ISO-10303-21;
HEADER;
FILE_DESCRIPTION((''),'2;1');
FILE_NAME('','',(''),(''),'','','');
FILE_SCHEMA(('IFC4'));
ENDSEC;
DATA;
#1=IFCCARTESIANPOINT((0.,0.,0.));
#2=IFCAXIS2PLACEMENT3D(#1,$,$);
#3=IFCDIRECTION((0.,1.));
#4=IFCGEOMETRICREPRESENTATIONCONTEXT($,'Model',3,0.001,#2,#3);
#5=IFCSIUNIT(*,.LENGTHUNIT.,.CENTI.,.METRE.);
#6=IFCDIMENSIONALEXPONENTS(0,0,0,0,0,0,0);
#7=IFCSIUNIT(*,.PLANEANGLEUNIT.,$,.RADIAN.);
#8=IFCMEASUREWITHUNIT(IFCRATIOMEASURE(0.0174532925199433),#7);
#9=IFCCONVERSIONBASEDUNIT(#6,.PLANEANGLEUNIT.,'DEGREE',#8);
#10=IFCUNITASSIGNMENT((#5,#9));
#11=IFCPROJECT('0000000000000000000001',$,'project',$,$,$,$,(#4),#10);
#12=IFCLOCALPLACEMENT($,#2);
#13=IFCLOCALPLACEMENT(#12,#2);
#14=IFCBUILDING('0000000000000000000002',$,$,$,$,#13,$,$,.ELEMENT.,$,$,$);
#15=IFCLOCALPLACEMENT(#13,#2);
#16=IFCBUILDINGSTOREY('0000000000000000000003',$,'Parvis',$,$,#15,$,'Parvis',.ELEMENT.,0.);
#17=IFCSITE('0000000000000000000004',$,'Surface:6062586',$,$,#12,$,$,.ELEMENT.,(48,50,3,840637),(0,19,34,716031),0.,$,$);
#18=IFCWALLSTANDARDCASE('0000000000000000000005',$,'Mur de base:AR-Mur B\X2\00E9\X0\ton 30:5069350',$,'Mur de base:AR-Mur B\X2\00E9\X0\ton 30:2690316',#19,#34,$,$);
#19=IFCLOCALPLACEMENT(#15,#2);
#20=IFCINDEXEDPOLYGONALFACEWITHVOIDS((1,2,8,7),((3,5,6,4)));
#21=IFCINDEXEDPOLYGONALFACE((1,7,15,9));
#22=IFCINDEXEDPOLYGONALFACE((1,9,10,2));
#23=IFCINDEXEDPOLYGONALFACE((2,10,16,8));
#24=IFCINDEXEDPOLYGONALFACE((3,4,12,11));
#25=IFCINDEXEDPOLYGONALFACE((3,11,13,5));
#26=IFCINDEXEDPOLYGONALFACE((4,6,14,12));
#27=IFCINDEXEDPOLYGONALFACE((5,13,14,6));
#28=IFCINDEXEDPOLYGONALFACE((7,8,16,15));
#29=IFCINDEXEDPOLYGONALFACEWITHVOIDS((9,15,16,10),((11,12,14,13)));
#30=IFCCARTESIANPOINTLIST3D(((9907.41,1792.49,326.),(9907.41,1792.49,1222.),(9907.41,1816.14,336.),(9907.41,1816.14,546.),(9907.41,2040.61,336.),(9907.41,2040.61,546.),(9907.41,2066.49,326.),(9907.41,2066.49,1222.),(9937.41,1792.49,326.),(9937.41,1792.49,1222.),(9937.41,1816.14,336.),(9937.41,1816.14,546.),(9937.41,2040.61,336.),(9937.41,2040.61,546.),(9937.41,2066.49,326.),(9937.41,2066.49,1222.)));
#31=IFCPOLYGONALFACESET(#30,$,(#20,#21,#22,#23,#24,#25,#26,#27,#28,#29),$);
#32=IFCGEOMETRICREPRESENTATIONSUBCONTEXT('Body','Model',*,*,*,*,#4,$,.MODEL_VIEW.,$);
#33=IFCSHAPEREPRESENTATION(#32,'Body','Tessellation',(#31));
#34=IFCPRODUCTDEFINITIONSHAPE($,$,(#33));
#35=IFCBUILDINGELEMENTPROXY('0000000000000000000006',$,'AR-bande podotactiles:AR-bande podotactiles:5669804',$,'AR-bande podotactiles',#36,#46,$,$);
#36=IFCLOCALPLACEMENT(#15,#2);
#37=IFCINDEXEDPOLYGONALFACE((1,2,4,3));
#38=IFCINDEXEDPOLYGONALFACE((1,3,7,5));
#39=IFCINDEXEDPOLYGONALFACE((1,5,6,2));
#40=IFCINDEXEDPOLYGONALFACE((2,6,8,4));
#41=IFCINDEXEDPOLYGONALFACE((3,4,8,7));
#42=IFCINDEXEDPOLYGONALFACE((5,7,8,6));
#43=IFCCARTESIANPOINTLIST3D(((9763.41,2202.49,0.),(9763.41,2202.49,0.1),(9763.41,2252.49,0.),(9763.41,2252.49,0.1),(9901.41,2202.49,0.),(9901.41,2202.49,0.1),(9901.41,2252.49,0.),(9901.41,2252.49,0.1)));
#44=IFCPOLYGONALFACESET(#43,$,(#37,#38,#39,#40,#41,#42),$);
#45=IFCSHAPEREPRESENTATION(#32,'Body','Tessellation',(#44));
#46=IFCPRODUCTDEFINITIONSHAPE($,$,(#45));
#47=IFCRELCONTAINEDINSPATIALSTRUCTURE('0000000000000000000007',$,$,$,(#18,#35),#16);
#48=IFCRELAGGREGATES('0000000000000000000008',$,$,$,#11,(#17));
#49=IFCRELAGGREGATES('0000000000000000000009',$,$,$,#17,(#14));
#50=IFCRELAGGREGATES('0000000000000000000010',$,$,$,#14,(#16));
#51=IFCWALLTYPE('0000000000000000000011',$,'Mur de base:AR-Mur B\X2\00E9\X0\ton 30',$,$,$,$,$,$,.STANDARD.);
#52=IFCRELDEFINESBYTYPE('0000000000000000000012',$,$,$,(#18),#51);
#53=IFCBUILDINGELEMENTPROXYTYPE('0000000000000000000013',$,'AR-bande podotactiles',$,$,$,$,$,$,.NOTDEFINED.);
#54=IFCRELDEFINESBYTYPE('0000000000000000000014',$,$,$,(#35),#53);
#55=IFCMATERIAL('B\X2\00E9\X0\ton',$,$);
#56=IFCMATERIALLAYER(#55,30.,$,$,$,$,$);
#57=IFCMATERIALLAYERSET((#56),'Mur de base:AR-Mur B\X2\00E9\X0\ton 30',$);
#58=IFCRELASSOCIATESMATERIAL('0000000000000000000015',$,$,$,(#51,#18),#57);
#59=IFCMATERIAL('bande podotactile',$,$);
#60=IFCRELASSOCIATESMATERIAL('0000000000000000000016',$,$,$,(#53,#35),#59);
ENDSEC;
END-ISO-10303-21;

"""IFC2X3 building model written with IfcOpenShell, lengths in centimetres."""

from ifc_helpers import new_model, entity, si_unit, converted_unit, direction, frame, frame_2d, origin, origin_2d_with_axis, place, context, subcontext, project, spatial, rectangle, extrude, source, transform, mapped, material, layer, layer_set, layer_usage, type_object, type_shapes, element, save


model = new_model("IFC2X3")

# Units and contexts
model_context = context("Model", 3, precision=0.001, world=origin(), true_north=direction((0.0, 1.0)))
body_context = subcontext(model_context, "Body", "Model", "MODEL_VIEW")
ifc_project = project(units=[si_unit("LENGTHUNIT", "METRE", prefix="CENTI"), converted_unit("PLANEANGLEUNIT", "DEGREE", entity("IfcRatioMeasure", 0.0174532925199433), si_unit("PLANEANGLEUNIT", "RADIAN"), dimensions=[0, 0, 0, 0, 0, 0, 0])], contexts=[model_context])

# Site, building, storey
site_placement = place(None, origin())
site = spatial("IfcSite", under=ifc_project, at=site_placement, Name="Surface:6062586", CompositionType="ELEMENT", RefLatitude=(48, 50, 3, 840637), RefLongitude=(0, 19, 34, 716031), RefElevation=0.0)
building_placement = place(site_placement, origin())
building = spatial("IfcBuilding", under=site, at=building_placement, CompositionType="ELEMENT")
storey_placement = place(building_placement, frame((0.0, 0.0, 0.0)))
storey = spatial("IfcBuildingStorey", under=building, at=storey_placement, Name="Parvis", LongName="Parvis", CompositionType="ELEMENT", Elevation=0.0)

# Wall, opening
ifc_material_1 = material(Name="Béton")
ifc_layer_1 = layer(ifc_material_1, 30.0)
ifc_layer_set_1 = layer_set([ifc_layer_1], Name="Mur de base:AR-Mur Béton 30")
ifc_layer_usage_1 = layer_usage(ifc_layer_set_1, "AXIS2", "NEGATIVE", 15.0)
wall_type = type_object("IfcWallType", Name="Mur de base:AR-Mur Béton 30", PredefinedType="STANDARD", material=ifc_layer_set_1)
wall_placement = place(storey_placement, frame((9922.41, 2066.49, 326.0), z_axis=(0.0, 0.0, 1.0), x_axis=(0.0, -1.0, 0.0)))
wall = element("IfcWallStandardCase", 1, at=wall_placement, inside=storey, type_object=wall_type, material=ifc_layer_usage_1, Name="Mur de base:AR-Mur Béton 30:5069350", ObjectType="Mur de base:AR-Mur Béton 30:2690316", context=body_context, shape_type="SweptSolid", body=[
    extrude(rectangle(XDim=274.0, YDim=30.0, at=frame_2d((137.0, 0.0), x_axis=(-1.0, 0.0))), origin(), (0.0, 0.0, 1.0), 896.0),
])
opening_placement = place(wall_placement, frame((250.35, -167.4, 10.0), z_axis=(0.0, 0.0, 1.0), x_axis=(0.0, 1.0, 0.0)))
element("IfcOpeningElement", 2, at=opening_placement, cuts=wall, ObjectType="Opening", context=body_context, shape_type="SweptSolid", body=[
    extrude(rectangle(XDim=210.0, YDim=224.47, at=frame_2d((0.0, 0.0), x_axis=(1.0, 0.0))), frame((0.0, 112.23, 105.0), z_axis=(1.0, 0.0, 0.0), x_axis=(0.0, 0.0, 1.0)), (0.0, 0.0, 1.0), 304.8),
])

# Building element proxy
ifc_material_2 = material(Name="bande podotactile")
building_element_proxy_type = type_object("IfcBuildingElementProxyType", Name="AR-bande podotactiles", PredefinedType="NOTDEFINED", material=ifc_material_2)
shared_shape_1 = source(origin(), body_context, "Body", "SweptSolid", [
    extrude(rectangle(XDim=138.0, YDim=50.0, at=origin_2d_with_axis()), frame((69.0, 25.0, 0.0), z_axis=(0.0, 0.0, 1.0), x_axis=(-1.0, 0.0, 0.0)), (0.0, 0.0, 1.0), 0.1),
])
type_shapes(building_element_proxy_type, [shared_shape_1])
proxy_placement = place(storey_placement, frame((9763.41, 2202.49, 0.0)))
element("IfcBuildingElementProxy", 3, at=proxy_placement, inside=storey, type_object=building_element_proxy_type, material=ifc_material_2, Name="AR-bande podotactiles:AR-bande podotactiles:5669804", ObjectType="AR-bande podotactiles", context=body_context, shape_type="MappedRepresentation", body=[
    mapped(shared_shape_1, transform((0.0, 0.0, 0.0), scale=1.0)),
])

save(model, "model.ifc")
